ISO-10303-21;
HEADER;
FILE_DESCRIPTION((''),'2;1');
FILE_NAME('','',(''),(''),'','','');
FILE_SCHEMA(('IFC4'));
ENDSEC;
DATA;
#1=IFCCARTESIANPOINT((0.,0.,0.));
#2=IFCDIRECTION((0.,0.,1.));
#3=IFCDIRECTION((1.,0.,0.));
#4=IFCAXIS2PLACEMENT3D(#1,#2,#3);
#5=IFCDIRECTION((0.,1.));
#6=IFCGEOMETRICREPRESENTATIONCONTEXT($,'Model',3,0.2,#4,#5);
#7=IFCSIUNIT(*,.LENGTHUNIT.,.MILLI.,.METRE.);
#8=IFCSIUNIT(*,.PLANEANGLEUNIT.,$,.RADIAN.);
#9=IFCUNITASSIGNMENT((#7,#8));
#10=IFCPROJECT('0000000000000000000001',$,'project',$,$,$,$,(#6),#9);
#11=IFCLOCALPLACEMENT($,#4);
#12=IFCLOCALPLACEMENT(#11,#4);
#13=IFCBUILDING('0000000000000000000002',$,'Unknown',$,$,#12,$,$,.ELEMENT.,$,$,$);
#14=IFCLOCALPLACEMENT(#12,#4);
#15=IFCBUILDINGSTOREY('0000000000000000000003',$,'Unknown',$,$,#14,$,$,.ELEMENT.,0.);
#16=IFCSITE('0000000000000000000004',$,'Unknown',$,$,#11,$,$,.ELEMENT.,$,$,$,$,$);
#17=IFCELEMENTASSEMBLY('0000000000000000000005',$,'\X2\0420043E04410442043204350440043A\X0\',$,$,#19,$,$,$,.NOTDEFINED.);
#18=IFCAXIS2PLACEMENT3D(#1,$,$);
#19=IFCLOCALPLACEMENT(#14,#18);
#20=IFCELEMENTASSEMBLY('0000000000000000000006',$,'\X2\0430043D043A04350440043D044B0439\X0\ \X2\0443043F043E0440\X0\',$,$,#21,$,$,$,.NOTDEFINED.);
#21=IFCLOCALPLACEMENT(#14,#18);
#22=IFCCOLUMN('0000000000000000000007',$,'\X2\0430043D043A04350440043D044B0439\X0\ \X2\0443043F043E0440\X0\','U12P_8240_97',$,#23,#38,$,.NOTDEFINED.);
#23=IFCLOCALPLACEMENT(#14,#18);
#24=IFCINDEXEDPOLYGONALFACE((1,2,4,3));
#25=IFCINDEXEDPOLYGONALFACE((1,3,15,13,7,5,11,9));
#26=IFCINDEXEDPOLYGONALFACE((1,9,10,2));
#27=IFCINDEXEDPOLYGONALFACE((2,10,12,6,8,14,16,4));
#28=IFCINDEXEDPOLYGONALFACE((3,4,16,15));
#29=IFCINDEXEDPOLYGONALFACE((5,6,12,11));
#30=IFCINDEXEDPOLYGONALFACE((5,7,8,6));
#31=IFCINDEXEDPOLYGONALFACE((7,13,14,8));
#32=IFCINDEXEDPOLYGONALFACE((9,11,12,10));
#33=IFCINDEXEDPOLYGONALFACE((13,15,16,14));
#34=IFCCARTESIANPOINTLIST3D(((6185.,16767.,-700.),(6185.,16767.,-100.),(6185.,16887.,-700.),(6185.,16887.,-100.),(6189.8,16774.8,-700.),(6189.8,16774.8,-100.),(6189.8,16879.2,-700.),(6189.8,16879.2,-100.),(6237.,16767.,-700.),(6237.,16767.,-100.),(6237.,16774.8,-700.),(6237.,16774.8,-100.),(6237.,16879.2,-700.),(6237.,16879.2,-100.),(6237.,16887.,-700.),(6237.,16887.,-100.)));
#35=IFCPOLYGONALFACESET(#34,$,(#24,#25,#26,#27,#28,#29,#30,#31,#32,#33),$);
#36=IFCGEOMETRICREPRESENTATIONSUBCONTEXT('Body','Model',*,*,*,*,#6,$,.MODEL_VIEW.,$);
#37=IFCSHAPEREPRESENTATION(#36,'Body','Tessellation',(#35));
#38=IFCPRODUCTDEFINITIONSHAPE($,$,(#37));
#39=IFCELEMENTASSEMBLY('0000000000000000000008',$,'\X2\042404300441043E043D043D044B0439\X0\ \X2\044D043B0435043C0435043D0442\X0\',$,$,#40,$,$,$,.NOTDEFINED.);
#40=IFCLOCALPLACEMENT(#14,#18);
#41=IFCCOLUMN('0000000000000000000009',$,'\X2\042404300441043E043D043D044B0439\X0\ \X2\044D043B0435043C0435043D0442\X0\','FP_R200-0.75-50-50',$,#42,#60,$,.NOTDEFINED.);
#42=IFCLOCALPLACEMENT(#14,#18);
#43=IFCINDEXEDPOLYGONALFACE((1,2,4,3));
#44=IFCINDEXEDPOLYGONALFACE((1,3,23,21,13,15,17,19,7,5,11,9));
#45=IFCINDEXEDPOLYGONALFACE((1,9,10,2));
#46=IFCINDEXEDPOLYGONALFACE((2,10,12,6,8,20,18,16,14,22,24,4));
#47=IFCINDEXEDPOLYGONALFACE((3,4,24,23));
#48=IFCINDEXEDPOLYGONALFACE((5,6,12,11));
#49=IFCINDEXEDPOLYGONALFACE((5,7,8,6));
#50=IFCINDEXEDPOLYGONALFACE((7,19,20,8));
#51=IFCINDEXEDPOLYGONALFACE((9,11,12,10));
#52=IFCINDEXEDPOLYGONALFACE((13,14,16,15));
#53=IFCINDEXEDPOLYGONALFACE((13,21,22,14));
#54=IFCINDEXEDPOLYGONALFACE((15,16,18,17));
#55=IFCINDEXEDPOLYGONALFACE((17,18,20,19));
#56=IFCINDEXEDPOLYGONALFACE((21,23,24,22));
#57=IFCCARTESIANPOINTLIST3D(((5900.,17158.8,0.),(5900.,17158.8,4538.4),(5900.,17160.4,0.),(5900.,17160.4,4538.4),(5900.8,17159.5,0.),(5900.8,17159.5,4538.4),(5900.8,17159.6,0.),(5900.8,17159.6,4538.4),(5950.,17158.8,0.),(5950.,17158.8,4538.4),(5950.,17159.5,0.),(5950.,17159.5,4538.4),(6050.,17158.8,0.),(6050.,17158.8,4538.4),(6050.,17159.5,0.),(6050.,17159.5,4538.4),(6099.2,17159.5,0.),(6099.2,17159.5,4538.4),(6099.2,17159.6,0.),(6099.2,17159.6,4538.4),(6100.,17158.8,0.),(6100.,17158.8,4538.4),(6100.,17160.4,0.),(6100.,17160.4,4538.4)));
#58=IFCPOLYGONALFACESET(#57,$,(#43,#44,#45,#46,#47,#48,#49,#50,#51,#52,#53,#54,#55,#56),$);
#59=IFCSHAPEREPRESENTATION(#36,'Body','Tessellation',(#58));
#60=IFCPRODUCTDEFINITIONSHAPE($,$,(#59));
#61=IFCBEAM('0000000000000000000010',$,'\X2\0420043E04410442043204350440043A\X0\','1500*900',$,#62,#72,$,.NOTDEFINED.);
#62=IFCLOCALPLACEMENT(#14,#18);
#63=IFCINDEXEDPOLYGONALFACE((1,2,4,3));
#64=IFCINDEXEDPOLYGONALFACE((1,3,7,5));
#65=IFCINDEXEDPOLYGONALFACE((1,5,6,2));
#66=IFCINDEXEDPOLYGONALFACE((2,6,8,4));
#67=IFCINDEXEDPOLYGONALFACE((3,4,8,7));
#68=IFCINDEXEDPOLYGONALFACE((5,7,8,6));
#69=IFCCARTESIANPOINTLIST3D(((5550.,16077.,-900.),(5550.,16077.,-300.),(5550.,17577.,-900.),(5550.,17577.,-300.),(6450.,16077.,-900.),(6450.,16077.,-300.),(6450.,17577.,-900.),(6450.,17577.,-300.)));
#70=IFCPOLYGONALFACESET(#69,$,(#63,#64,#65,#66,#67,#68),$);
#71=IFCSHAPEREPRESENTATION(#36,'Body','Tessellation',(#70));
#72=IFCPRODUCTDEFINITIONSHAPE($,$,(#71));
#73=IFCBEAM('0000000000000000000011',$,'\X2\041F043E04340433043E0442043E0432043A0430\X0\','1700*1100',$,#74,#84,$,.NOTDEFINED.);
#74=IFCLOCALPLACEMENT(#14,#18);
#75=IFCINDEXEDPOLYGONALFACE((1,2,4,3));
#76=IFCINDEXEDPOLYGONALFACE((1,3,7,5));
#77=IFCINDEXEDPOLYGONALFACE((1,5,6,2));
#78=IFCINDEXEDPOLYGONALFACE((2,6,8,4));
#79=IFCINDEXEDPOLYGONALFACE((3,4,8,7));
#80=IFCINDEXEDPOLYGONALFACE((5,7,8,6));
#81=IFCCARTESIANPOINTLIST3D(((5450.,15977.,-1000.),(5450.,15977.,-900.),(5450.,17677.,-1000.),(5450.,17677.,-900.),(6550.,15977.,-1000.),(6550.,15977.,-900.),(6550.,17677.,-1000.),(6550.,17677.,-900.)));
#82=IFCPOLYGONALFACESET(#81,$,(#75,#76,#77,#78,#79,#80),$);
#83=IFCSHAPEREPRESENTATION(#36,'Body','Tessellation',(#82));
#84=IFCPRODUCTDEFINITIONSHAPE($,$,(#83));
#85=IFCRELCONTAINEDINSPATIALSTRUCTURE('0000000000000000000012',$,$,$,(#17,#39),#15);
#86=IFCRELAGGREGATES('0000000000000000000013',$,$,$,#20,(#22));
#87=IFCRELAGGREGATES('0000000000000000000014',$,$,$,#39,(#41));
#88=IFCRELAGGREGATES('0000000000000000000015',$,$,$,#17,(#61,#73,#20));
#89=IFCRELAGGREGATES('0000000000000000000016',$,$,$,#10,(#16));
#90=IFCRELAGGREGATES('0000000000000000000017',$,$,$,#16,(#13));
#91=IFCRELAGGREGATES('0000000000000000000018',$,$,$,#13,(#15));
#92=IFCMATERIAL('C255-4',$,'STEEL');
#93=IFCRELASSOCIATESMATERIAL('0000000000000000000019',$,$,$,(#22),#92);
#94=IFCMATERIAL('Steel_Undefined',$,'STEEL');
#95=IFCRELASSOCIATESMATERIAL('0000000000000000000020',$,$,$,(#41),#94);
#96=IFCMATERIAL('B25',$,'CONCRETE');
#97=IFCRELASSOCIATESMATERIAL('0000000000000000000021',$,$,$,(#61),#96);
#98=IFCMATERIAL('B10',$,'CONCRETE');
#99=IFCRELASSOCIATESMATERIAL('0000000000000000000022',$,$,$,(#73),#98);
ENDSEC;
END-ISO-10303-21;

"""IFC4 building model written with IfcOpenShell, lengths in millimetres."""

from ifc_helpers import new_model, si_unit, direction, frame, origin_with_axes, place, context, subcontext, project, spatial, line, indexed_curve, outline, extrude, material, element, aggregate, save


model = new_model("IFC4")

# Units and contexts
model_context = context("Model", 3, precision=0.2, world=origin_with_axes(), true_north=direction((0.0, 1.0)))
body_context = subcontext(model_context, "Body", "Model", "MODEL_VIEW")
ifc_project = project(units=[si_unit("LENGTHUNIT", "METRE", prefix="MILLI"), si_unit("PLANEANGLEUNIT", "RADIAN")], contexts=[model_context])

# Site, building, storey
site_placement = place(None, origin_with_axes())
site = spatial("IfcSite", under=ifc_project, at=site_placement, Name="Unknown", CompositionType="ELEMENT")
building_placement = place(site_placement, origin_with_axes())
building = spatial("IfcBuilding", under=site, at=building_placement, Name="Unknown", CompositionType="ELEMENT")
storey_placement = place(building_placement, origin_with_axes())
storey = spatial("IfcBuildingStorey", under=building, at=storey_placement, Name="Unknown", CompositionType="ELEMENT", Elevation=0.0)

# Element assemblies, column
assembly_1_placement = place(storey_placement, frame((6000.0, 16827.0, -300.0), z_axis=(-1.0, 0.0, 0.0), x_axis=(0.0, 0.0, -1.0)))
assembly_1 = element("IfcElementAssembly", 1, at=assembly_1_placement, inside=storey, Name="Ростверк", PredefinedType="NOTDEFINED")
assembly_2_placement = place(assembly_1_placement, frame((400.0, 0.0, -211.0), z_axis=(0.0, 0.0, -1.0), x_axis=(-1.0, 0.0, 0.0)))
assembly_2 = element("IfcElementAssembly", 2, at=assembly_2_placement, Name="анкерный упор", PredefinedType="NOTDEFINED")
ifc_material_1 = material(Name="C255-4", Category="STEEL")
column_1_placement = place(assembly_2_placement, origin_with_axes())
column_1 = element("IfcColumn", 3, at=column_1_placement, material=ifc_material_1, Name="анкерный упор", Description="U12P_8240_97", PredefinedType="NOTDEFINED", context=body_context, shape_type="SolidModel", body=[
    extrude(outline(indexed_curve([(-26.0, -60.0), (26.0, -60.0), (26.0, -52.2), (-21.2, -52.2), (-21.2, 52.2), (26.0, 52.2), (26.0, 60.0), (-26.0, 60.0)], segments=[line(1, 2, 3, 4, 5, 6, 7, 8, 1)])), frame((0.0, 0.0, 0.0), z_axis=(-1.0, 0.0, 0.0), x_axis=(0.0, 0.0, 1.0)), (0.0, 0.0, -1.0), 600.0),
])
aggregate(assembly_2, [column_1])

# Element assembly, column
assembly_3_placement = place(storey_placement, frame((6000.0, 17160.0, 0.0), z_axis=(0.0, -1.0, 0.0), x_axis=(0.0, 0.0, 1.0)))
assembly_3 = element("IfcElementAssembly", 4, at=assembly_3_placement, inside=storey, Name="Фасонный элемент", PredefinedType="NOTDEFINED")
ifc_material_2 = material(Name="Steel_Undefined", Category="STEEL")
column_2_placement = place(assembly_3_placement, origin_with_axes())
column_2 = element("IfcColumn", 5, at=column_2_placement, material=ifc_material_2, Name="Фасонный элемент", Description="FP_R200-0.75-50-50", PredefinedType="NOTDEFINED", context=body_context, shape_type="SolidModel", body=[
    extrude(outline(indexed_curve([(-0.4, -100.0), (1.2, -100.0), (1.2, -50.0), (0.5, -50.0), (0.5, -99.2), (0.4, -99.2), (0.4, 99.2), (0.5, 99.2), (0.5, 50.0), (1.2, 50.0), (1.2, 100.0), (-0.4, 100.0)], segments=[line(1, 2, 3, 4, 5, 6, 7, 8, 9, 10, 11, 12, 1)])), frame((0.0, 0.0, 0.0), z_axis=(-1.0, 0.0, 0.0), x_axis=(0.0, 0.0, 1.0)), (0.0, 0.0, -1.0), 4538.4),
])
aggregate(assembly_3, [column_2])

# Beams
ifc_material_3 = material(Name="B25", Category="CONCRETE")
beam_1_placement = place(assembly_1_placement, origin_with_axes())
beam_1 = element("IfcBeam", 6, at=beam_1_placement, material=ifc_material_3, Name="Ростверк", Description="1500*900", PredefinedType="NOTDEFINED", context=body_context, shape_type="SolidModel", body=[
    extrude(outline(indexed_curve([(-450.0, -750.0), (450.0, -750.0), (450.0, 750.0), (-450.0, 750.0)], segments=[line(1, 2, 3, 4, 1)])), frame((0.0, 0.0, 0.0), z_axis=(-1.0, 0.0, 0.0), x_axis=(0.0, 0.0, 1.0)), (0.0, 0.0, -1.0), 600.0),
])
ifc_material_4 = material(Name="B10", Category="CONCRETE")
beam_2_placement = place(assembly_1_placement, frame((600.0, 0.0, 0.0), z_axis=(0.0, 0.0, 1.0), x_axis=(1.0, 0.0, 0.0)))
beam_2 = element("IfcBeam", 7, at=beam_2_placement, material=ifc_material_4, Name="Подготовка", Description="1700*1100", PredefinedType="NOTDEFINED", context=body_context, shape_type="SolidModel", body=[
    extrude(outline(indexed_curve([(-550.0, -850.0), (550.0, -850.0), (550.0, 850.0), (-550.0, 850.0)], segments=[line(1, 2, 3, 4, 1)])), frame((0.0, 0.0, 0.0), z_axis=(-1.0, 0.0, 0.0), x_axis=(0.0, 0.0, 1.0)), (0.0, 0.0, -1.0), 100.0),
])

aggregate(assembly_1, [beam_1, beam_2, assembly_2])

save(model, "model.ifc")
